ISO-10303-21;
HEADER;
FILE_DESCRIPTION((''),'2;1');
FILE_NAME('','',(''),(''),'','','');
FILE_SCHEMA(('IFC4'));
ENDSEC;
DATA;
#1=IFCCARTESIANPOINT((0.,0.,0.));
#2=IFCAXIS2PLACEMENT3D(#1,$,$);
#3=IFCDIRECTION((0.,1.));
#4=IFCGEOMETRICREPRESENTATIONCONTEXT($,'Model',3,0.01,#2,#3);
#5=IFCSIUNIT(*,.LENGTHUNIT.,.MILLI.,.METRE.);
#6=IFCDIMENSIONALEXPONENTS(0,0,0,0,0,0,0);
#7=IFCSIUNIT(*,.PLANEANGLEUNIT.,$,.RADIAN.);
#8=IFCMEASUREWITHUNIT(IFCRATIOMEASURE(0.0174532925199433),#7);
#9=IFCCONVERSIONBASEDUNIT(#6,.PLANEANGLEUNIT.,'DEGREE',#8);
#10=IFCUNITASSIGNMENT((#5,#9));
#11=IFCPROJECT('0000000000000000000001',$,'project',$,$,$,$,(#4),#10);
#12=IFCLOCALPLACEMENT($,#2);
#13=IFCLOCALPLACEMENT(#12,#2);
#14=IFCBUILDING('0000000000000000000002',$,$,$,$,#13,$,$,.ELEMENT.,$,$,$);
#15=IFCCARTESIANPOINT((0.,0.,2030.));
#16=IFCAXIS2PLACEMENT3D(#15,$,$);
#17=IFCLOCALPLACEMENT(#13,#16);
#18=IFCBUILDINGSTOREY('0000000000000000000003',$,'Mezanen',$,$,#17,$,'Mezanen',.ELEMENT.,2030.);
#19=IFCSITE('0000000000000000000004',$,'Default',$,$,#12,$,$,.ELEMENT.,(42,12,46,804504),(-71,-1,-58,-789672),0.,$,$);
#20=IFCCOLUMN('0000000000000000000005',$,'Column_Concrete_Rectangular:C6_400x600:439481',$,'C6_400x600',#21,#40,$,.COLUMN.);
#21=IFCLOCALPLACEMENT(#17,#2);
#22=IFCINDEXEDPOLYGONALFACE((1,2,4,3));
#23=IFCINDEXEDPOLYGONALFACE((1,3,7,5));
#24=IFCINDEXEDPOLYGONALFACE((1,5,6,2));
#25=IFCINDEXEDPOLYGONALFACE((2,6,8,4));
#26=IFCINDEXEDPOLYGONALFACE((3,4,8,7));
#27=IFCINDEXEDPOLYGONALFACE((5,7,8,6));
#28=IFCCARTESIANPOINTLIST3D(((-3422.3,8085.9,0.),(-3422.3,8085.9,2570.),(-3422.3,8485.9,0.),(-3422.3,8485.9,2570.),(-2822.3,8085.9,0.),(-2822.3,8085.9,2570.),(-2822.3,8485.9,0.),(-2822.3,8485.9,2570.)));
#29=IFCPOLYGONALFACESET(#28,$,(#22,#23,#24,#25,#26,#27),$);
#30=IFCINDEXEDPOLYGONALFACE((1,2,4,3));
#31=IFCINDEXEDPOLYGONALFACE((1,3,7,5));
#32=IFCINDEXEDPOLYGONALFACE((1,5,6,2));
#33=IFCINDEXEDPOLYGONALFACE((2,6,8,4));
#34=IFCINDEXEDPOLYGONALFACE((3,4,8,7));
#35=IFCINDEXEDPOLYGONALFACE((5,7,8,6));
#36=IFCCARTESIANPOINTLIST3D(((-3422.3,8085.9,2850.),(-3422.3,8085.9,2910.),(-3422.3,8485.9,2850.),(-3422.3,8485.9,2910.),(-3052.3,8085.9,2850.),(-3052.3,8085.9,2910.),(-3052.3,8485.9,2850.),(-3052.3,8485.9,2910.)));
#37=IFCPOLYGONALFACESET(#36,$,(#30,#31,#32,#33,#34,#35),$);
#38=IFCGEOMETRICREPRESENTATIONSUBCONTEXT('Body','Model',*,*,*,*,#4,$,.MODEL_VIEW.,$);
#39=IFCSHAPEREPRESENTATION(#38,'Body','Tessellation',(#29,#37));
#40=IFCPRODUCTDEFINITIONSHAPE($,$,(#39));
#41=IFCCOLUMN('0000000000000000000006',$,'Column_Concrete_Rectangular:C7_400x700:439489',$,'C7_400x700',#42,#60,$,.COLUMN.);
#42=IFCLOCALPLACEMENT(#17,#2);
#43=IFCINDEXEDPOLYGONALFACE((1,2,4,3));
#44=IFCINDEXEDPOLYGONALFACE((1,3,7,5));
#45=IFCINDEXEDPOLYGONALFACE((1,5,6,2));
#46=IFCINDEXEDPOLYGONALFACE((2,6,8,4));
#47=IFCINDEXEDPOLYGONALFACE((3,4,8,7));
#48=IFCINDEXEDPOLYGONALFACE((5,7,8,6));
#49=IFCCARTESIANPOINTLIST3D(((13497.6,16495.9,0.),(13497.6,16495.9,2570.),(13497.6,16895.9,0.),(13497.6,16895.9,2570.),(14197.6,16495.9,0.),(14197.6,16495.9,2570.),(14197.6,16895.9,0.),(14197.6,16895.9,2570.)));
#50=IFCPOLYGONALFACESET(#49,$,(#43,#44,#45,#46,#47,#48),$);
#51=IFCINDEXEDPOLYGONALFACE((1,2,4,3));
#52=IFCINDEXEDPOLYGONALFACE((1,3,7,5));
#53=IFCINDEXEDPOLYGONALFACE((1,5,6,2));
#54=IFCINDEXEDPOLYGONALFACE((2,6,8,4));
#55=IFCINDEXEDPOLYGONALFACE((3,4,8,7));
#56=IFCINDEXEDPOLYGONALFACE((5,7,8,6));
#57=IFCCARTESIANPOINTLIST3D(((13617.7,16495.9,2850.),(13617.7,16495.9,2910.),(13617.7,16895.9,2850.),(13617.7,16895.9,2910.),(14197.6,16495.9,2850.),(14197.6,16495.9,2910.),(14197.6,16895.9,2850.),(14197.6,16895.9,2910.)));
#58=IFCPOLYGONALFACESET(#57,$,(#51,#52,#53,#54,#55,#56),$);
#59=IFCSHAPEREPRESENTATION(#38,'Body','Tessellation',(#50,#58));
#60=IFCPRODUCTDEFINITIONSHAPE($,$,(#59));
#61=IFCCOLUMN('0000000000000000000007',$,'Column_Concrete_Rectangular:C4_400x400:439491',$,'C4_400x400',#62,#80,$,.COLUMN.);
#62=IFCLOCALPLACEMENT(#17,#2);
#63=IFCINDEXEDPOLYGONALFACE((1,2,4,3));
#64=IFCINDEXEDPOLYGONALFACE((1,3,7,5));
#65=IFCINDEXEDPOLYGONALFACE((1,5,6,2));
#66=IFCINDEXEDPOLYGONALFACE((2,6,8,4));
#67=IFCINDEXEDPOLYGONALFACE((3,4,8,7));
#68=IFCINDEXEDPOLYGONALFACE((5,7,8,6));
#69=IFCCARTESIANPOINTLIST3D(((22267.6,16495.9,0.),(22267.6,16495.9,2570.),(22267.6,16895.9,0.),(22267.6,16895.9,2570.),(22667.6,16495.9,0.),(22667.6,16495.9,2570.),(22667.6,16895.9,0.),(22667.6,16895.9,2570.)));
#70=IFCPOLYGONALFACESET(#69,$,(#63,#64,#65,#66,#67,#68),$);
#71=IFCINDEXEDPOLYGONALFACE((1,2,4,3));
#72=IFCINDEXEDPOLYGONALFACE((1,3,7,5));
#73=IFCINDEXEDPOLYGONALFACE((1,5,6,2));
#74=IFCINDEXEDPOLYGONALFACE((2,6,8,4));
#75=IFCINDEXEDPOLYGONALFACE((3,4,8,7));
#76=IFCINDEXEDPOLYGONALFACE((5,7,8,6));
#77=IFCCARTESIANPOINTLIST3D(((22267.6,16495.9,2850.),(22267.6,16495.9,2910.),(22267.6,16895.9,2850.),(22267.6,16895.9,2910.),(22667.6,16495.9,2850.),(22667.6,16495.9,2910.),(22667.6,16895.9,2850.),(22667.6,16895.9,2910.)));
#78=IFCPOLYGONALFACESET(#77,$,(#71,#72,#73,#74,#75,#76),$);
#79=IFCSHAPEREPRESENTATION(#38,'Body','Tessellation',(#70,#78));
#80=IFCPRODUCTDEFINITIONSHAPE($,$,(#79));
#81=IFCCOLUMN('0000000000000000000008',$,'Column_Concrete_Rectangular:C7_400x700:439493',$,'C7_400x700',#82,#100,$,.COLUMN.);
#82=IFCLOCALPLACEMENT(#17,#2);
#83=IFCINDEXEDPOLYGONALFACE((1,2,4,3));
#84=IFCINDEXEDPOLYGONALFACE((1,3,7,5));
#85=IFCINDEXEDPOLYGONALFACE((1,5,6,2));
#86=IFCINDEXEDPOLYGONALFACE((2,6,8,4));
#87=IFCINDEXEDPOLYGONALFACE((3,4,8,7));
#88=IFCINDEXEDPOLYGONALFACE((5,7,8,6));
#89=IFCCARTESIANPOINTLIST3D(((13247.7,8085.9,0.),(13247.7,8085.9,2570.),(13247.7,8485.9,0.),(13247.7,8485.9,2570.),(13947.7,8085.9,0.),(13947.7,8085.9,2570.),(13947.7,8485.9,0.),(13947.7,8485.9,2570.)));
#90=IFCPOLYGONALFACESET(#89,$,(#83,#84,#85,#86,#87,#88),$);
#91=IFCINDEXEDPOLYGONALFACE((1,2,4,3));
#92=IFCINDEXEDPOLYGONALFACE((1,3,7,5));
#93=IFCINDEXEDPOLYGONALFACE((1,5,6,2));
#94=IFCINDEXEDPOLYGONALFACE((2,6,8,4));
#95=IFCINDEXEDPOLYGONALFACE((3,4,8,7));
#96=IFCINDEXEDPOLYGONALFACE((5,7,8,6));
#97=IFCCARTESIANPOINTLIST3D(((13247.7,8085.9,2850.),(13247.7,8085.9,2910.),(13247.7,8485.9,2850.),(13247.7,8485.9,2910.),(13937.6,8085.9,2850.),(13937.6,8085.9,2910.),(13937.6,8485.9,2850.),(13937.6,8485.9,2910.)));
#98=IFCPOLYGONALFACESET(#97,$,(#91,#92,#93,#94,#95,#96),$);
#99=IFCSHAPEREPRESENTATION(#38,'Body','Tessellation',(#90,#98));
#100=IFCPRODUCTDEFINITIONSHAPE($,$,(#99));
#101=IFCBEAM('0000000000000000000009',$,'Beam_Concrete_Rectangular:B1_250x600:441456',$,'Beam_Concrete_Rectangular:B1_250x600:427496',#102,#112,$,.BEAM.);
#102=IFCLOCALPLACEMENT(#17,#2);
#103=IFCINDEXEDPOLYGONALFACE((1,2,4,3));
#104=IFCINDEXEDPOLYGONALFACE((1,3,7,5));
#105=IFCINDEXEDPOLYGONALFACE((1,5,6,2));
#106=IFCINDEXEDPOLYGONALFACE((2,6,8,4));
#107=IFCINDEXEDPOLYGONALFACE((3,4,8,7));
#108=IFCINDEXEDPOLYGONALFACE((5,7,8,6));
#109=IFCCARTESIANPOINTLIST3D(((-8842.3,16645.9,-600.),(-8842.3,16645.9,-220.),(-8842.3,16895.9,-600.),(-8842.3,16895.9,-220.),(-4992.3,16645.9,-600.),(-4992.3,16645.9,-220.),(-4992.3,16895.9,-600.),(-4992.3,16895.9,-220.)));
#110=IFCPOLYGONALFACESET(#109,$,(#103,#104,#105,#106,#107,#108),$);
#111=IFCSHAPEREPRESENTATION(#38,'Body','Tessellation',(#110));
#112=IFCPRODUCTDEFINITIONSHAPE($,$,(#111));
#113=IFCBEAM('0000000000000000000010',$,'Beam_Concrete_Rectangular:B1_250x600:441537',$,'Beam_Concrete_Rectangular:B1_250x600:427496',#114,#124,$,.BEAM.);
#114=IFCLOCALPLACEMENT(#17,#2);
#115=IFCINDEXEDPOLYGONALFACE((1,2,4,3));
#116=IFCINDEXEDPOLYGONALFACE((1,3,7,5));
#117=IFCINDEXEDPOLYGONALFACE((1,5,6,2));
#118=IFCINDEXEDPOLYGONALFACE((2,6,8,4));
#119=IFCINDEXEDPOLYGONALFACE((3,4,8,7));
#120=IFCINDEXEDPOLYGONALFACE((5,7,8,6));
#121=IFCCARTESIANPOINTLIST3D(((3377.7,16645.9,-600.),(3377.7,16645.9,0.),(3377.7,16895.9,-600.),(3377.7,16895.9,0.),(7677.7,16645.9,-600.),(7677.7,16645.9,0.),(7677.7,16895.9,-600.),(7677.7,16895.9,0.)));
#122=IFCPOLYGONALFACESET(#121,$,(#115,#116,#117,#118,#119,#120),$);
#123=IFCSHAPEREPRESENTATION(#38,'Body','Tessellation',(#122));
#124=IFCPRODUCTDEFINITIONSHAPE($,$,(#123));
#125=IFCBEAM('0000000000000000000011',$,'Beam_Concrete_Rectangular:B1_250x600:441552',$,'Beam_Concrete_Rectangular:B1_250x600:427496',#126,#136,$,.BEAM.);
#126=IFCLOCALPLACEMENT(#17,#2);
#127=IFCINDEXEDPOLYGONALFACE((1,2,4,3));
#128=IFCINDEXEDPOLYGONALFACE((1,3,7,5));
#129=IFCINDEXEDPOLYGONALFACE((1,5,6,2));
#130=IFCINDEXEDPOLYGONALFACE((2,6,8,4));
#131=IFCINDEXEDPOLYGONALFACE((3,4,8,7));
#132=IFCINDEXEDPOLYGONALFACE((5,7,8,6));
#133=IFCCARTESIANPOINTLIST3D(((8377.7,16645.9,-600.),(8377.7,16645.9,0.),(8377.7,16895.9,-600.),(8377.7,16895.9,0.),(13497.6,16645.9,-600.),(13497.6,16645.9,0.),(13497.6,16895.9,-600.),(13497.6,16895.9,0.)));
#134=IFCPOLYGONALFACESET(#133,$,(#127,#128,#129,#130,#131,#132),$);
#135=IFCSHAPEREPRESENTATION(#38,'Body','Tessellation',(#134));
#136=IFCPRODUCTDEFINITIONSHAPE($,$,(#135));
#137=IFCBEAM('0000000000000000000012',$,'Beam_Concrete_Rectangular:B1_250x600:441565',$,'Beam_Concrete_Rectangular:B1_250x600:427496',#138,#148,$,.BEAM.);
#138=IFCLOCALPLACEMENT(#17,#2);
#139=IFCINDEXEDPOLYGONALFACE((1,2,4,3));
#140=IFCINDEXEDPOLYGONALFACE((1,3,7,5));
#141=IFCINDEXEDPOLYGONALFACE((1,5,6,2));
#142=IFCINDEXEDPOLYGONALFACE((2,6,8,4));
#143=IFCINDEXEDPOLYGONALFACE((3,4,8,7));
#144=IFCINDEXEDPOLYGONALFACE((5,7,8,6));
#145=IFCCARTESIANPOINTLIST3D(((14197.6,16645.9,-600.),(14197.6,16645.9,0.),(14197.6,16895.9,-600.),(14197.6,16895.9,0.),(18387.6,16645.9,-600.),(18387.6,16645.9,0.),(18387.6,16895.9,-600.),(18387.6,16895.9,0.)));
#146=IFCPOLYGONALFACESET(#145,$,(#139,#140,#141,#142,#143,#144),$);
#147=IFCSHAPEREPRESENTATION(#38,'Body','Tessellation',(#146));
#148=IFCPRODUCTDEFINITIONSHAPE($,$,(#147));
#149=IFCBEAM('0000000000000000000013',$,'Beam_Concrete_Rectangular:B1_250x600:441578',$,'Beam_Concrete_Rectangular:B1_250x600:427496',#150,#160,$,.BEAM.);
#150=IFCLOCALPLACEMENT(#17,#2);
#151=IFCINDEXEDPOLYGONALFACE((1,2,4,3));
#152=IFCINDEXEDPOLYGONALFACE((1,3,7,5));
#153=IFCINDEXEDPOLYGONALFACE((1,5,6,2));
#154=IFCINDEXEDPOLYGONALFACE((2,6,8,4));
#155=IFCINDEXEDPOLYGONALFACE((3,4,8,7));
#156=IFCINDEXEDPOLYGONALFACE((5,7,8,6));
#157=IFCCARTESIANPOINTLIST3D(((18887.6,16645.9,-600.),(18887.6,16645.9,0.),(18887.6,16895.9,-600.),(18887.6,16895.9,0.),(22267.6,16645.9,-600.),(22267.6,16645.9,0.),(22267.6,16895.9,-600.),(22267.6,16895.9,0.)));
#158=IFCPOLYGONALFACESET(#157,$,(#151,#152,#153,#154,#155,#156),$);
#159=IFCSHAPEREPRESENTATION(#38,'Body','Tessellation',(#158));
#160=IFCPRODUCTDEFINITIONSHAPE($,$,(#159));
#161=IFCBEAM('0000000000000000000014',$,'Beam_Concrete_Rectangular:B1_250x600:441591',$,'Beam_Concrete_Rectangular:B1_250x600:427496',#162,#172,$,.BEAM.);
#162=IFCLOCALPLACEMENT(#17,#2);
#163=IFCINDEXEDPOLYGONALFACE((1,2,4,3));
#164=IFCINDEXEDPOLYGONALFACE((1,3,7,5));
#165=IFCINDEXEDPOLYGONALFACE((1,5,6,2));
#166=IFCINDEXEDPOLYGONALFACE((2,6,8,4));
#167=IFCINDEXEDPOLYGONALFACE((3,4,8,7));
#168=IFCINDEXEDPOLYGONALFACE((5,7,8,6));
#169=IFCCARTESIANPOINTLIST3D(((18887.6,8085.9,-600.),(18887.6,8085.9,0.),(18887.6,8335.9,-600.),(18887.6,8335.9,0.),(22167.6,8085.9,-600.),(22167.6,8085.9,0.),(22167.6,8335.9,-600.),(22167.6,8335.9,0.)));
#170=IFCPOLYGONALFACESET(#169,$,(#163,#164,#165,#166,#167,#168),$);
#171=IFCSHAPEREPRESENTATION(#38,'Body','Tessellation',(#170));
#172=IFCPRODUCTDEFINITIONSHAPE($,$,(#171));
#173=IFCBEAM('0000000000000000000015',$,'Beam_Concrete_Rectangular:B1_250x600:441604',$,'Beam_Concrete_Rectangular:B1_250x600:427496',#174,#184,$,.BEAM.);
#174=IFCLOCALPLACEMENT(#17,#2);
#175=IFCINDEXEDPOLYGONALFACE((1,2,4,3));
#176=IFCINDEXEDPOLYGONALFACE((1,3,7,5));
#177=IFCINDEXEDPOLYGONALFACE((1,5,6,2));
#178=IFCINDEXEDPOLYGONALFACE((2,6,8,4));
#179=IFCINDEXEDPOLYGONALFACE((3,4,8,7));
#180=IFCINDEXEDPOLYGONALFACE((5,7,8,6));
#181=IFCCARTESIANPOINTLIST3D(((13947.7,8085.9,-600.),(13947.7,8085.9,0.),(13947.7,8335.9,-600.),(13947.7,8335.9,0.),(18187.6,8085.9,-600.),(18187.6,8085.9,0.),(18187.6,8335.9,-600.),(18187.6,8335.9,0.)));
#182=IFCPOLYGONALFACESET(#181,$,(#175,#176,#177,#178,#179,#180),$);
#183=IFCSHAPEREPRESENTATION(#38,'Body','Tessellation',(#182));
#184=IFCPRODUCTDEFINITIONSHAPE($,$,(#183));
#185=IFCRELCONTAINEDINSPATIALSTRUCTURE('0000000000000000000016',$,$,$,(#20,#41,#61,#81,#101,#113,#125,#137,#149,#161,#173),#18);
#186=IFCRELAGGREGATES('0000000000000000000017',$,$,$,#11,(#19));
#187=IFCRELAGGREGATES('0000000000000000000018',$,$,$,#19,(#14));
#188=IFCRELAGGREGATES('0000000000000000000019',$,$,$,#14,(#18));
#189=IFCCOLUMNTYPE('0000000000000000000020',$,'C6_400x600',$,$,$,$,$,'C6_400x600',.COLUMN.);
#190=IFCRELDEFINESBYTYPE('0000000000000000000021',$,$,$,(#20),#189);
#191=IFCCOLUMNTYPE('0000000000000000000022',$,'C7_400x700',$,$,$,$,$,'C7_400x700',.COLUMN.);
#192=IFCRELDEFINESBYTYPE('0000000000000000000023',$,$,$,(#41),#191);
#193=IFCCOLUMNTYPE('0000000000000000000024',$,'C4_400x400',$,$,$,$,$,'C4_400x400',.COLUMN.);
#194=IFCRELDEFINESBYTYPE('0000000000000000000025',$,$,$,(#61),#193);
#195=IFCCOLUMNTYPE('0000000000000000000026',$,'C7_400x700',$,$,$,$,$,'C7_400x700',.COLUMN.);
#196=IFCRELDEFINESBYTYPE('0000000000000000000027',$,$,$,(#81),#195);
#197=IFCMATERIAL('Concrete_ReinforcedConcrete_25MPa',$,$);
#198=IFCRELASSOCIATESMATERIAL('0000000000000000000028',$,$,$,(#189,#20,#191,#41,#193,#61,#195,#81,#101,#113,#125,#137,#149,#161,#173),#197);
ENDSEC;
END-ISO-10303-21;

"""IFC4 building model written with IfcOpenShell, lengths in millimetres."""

from ifc_helpers import new_model, entity, si_unit, converted_unit, direction, frame, frame_2d, origin, origin_2d_with_axis, place, context, subcontext, project, spatial, rectangle, extrude, source, transform, mapped, material, type_object, type_shapes, element, save


model = new_model("IFC4")

# Units and contexts
model_context = context("Model", 3, precision=0.01, world=origin(), true_north=direction((0.0, 1.0)))
body_context = subcontext(model_context, "Body", "Model", "MODEL_VIEW")
ifc_project = project(units=[si_unit("LENGTHUNIT", "METRE", prefix="MILLI"), converted_unit("PLANEANGLEUNIT", "DEGREE", entity("IfcRatioMeasure", 0.0174532925199433), si_unit("PLANEANGLEUNIT", "RADIAN"), dimensions=[0, 0, 0, 0, 0, 0, 0])], contexts=[model_context])

# Site, building, storey
site_placement = place(None, origin())
site = spatial("IfcSite", under=ifc_project, at=site_placement, Name="Default", CompositionType="ELEMENT", RefLatitude=(42, 12, 46, 804504), RefLongitude=(-71, -1, -58, -789672), RefElevation=0.0)
building_placement = place(site_placement, origin())
building = spatial("IfcBuilding", under=site, at=building_placement, CompositionType="ELEMENT")
storey_placement = place(building_placement, frame((0.0, 0.0, 2030.0)))
storey = spatial("IfcBuildingStorey", under=building, at=storey_placement, Name="Mezanen", LongName="Mezanen", CompositionType="ELEMENT", Elevation=2030.0)

# Columns
ifc_material = material(Name="Concrete_ReinforcedConcrete_25MPa")
column_type_1 = type_object("IfcColumnType", Name="C6_400x600", ElementType="C6_400x600", PredefinedType="COLUMN", material=ifc_material)
shared_shape_1 = source(origin(), body_context, "Body", "SweptSolid", [
    extrude(rectangle(XDim=400.0, YDim=600.0, at=origin_2d_with_axis()), frame((-3122.3, 8285.9, 2030.0), z_axis=(0.0, 0.0, 1.0), x_axis=(0.0, -1.0, 0.0)), (0.0, 0.0, 1.0), 2570.0),
    extrude(rectangle(XDim=400.0, YDim=370.0, at=frame_2d((0.0, 0.0), x_axis=(1.0, 0.0))), frame((-3237.3, 8285.9, 4880.0), z_axis=(0.0, 0.0, 1.0), x_axis=(0.0, -1.0, 0.0)), (0.0, 0.0, 1.0), 60.0),
])
type_shapes(column_type_1, [shared_shape_1])
column_1_placement = place(storey_placement, frame((0.0, 0.0, -2030.0)))
element("IfcColumn", 1, at=column_1_placement, inside=storey, type_object=column_type_1, material=ifc_material, Name="Column_Concrete_Rectangular:C6_400x600:439481", ObjectType="C6_400x600", PredefinedType="COLUMN", context=body_context, shape_type="MappedRepresentation", body=[
    mapped(shared_shape_1, transform((0.0, 0.0, 0.0), scale=1.0)),
])
column_type_2 = type_object("IfcColumnType", Name="C7_400x700", ElementType="C7_400x700", PredefinedType="COLUMN", material=ifc_material)
shared_shape_2 = source(origin(), body_context, "Body", "SweptSolid", [
    extrude(rectangle(XDim=400.0, YDim=700.0, at=frame_2d((0.0, 0.0), x_axis=(1.0, 0.0))), frame((13847.6, 16695.9, 2030.0), z_axis=(0.0, 0.0, 1.0), x_axis=(0.0, -1.0, 0.0)), (0.0, 0.0, 1.0), 2570.0),
    extrude(rectangle(XDim=400.0, YDim=580.0, at=frame_2d((0.0, 0.0), x_axis=(1.0, 0.0))), frame((13907.6, 16695.9, 4880.0), z_axis=(0.0, 0.0, 1.0), x_axis=(0.0, -1.0, 0.0)), (0.0, 0.0, 1.0), 60.0),
])
type_shapes(column_type_2, [shared_shape_2])
column_2_placement = place(storey_placement, frame((0.0, 0.0, -2030.0)))
element("IfcColumn", 2, at=column_2_placement, inside=storey, type_object=column_type_2, material=ifc_material, Name="Column_Concrete_Rectangular:C7_400x700:439489", ObjectType="C7_400x700", PredefinedType="COLUMN", context=body_context, shape_type="MappedRepresentation", body=[
    mapped(shared_shape_2, transform((0.0, 0.0, 0.0), scale=1.0)),
])
column_type_3 = type_object("IfcColumnType", Name="C4_400x400", ElementType="C4_400x400", PredefinedType="COLUMN", material=ifc_material)
shared_shape_3 = source(origin(), body_context, "Body", "SweptSolid", [
    extrude(rectangle(XDim=400.0, YDim=400.0, at=frame_2d((0.0, 0.0), x_axis=(1.0, 0.0))), frame((22467.6, 16695.9, 2030.0), z_axis=(0.0, 0.0, 1.0), x_axis=(0.0, -1.0, 0.0)), (0.0, 0.0, 1.0), 2570.0),
    extrude(rectangle(XDim=400.0, YDim=400.0, at=frame_2d((0.0, 0.0), x_axis=(1.0, 0.0))), frame((22467.6, 16695.9, 4880.0), z_axis=(0.0, 0.0, 1.0), x_axis=(0.0, -1.0, 0.0)), (0.0, 0.0, 1.0), 60.0),
])
type_shapes(column_type_3, [shared_shape_3])
column_3_placement = place(storey_placement, frame((0.0, 0.0, -2030.0)))
element("IfcColumn", 3, at=column_3_placement, inside=storey, type_object=column_type_3, material=ifc_material, Name="Column_Concrete_Rectangular:C4_400x400:439491", ObjectType="C4_400x400", PredefinedType="COLUMN", context=body_context, shape_type="MappedRepresentation", body=[
    mapped(shared_shape_3, transform((0.0, 0.0, 0.0), scale=1.0)),
])
column_type_4 = type_object("IfcColumnType", Name="C7_400x700", ElementType="C7_400x700", PredefinedType="COLUMN", material=ifc_material)
shared_shape_4 = source(origin(), body_context, "Body", "SweptSolid", [
    extrude(rectangle(XDim=400.0, YDim=700.0, at=frame_2d((0.0, 0.0), x_axis=(1.0, 0.0))), frame((13597.7, 8285.9, 2030.0), z_axis=(0.0, 0.0, 1.0), x_axis=(0.0, -1.0, 0.0)), (0.0, 0.0, 1.0), 2570.0),
    extrude(rectangle(XDim=400.0, YDim=690.0, at=frame_2d((0.0, 0.0), x_axis=(1.0, 0.0))), frame((13592.6, 8285.9, 4880.0), z_axis=(0.0, 0.0, 1.0), x_axis=(0.0, -1.0, 0.0)), (0.0, 0.0, 1.0), 60.0),
])
type_shapes(column_type_4, [shared_shape_4])
column_4_placement = place(storey_placement, frame((0.0, 0.0, -2030.0)))
element("IfcColumn", 4, at=column_4_placement, inside=storey, type_object=column_type_4, material=ifc_material, Name="Column_Concrete_Rectangular:C7_400x700:439493", ObjectType="C7_400x700", PredefinedType="COLUMN", context=body_context, shape_type="MappedRepresentation", body=[
    mapped(shared_shape_4, transform((0.0, 0.0, 0.0), scale=1.0)),
])

# Beams
beam_1_placement = place(storey_placement, frame((-9042.3, 16645.9, 0.0)))
element("IfcBeam", 5, at=beam_1_placement, inside=storey, material=ifc_material, Name="Beam_Concrete_Rectangular:B1_250x600:441456", ObjectType="Beam_Concrete_Rectangular:B1_250x600:427496", PredefinedType="BEAM", context=body_context, shape_type="SweptSolid", body=[
    extrude(rectangle(XDim=380.0, YDim=250.0, at=frame_2d((0.0, 0.0), x_axis=(1.0, 0.0))), frame((200.0, 125.0, -410.0), z_axis=(1.0, 0.0, 0.0), x_axis=(0.0, 0.0, -1.0)), (0.0, 0.0, 1.0), 3850.0),
])
beam_2_placement = place(storey_placement, frame((8027.7, 16895.9, 0.0), z_axis=(0.0, 0.0, 1.0), x_axis=(-1.0, 0.0, 0.0)))
element("IfcBeam", 6, at=beam_2_placement, inside=storey, material=ifc_material, Name="Beam_Concrete_Rectangular:B1_250x600:441537", ObjectType="Beam_Concrete_Rectangular:B1_250x600:427496", PredefinedType="BEAM", context=body_context, shape_type="SweptSolid", body=[
    extrude(rectangle(XDim=600.0, YDim=250.0, at=frame_2d((0.0, 0.0), x_axis=(1.0, 0.0))), frame((350.0, 125.0, -300.0), z_axis=(1.0, 0.0, 0.0), x_axis=(0.0, 0.0, -1.0)), (0.0, 0.0, 1.0), 4300.0),
])
beam_3_placement = place(storey_placement, frame((13847.6, 16895.9, 0.0), z_axis=(0.0, 0.0, 1.0), x_axis=(-1.0, 0.0, 0.0)))
element("IfcBeam", 7, at=beam_3_placement, inside=storey, material=ifc_material, Name="Beam_Concrete_Rectangular:B1_250x600:441552", ObjectType="Beam_Concrete_Rectangular:B1_250x600:427496", PredefinedType="BEAM", context=body_context, shape_type="SweptSolid", body=[
    extrude(rectangle(XDim=600.0, YDim=250.0, at=frame_2d((0.0, 0.0), x_axis=(1.0, 0.0))), frame((350.0, 125.0, -300.0), z_axis=(1.0, 0.0, 0.0), x_axis=(0.0, 0.0, -1.0)), (0.0, 0.0, 1.0), 5120.0),
])
beam_4_placement = place(storey_placement, frame((18637.6, 16895.9, 0.0), z_axis=(0.0, 0.0, 1.0), x_axis=(-1.0, 0.0, 0.0)))
element("IfcBeam", 8, at=beam_4_placement, inside=storey, material=ifc_material, Name="Beam_Concrete_Rectangular:B1_250x600:441565", ObjectType="Beam_Concrete_Rectangular:B1_250x600:427496", PredefinedType="BEAM", context=body_context, shape_type="SweptSolid", body=[
    extrude(rectangle(XDim=600.0, YDim=250.0, at=frame_2d((0.0, 0.0), x_axis=(1.0, 0.0))), frame((250.0, 125.0, -300.0), z_axis=(1.0, 0.0, 0.0), x_axis=(0.0, 0.0, -1.0)), (0.0, 0.0, 1.0), 4190.0),
])
beam_5_placement = place(storey_placement, frame((22467.6, 16895.9, 0.0), z_axis=(0.0, 0.0, 1.0), x_axis=(-1.0, 0.0, 0.0)))
element("IfcBeam", 9, at=beam_5_placement, inside=storey, material=ifc_material, Name="Beam_Concrete_Rectangular:B1_250x600:441578", ObjectType="Beam_Concrete_Rectangular:B1_250x600:427496", PredefinedType="BEAM", context=body_context, shape_type="SweptSolid", body=[
    extrude(rectangle(XDim=600.0, YDim=250.0, at=frame_2d((0.0, 0.0), x_axis=(1.0, 0.0))), frame((200.0, 125.0, -300.0), z_axis=(1.0, 0.0, 0.0), x_axis=(0.0, 0.0, -1.0)), (0.0, 0.0, 1.0), 3380.0),
])
beam_6_placement = place(storey_placement, frame((18537.6, 8085.9, 0.0)))
element("IfcBeam", 10, at=beam_6_placement, inside=storey, material=ifc_material, Name="Beam_Concrete_Rectangular:B1_250x600:441591", ObjectType="Beam_Concrete_Rectangular:B1_250x600:427496", PredefinedType="BEAM", context=body_context, shape_type="SweptSolid", body=[
    extrude(rectangle(XDim=600.0, YDim=250.0, at=frame_2d((0.0, 0.0), x_axis=(1.0, 0.0))), frame((350.0, 125.0, -300.0), z_axis=(1.0, 0.0, 0.0), x_axis=(0.0, 0.0, -1.0)), (0.0, 0.0, 1.0), 3280.0),
])
beam_7_placement = place(storey_placement, frame((13597.7, 8085.9, 0.0)))
element("IfcBeam", 11, at=beam_7_placement, inside=storey, material=ifc_material, Name="Beam_Concrete_Rectangular:B1_250x600:441604", ObjectType="Beam_Concrete_Rectangular:B1_250x600:427496", PredefinedType="BEAM", context=body_context, shape_type="SweptSolid", body=[
    extrude(rectangle(XDim=600.0, YDim=250.0, at=frame_2d((0.0, 0.0), x_axis=(1.0, 0.0))), frame((350.0, 125.0, -300.0), z_axis=(1.0, 0.0, 0.0), x_axis=(0.0, 0.0, -1.0)), (0.0, 0.0, 1.0), 4240.0),
])

save(model, "model.ifc")
